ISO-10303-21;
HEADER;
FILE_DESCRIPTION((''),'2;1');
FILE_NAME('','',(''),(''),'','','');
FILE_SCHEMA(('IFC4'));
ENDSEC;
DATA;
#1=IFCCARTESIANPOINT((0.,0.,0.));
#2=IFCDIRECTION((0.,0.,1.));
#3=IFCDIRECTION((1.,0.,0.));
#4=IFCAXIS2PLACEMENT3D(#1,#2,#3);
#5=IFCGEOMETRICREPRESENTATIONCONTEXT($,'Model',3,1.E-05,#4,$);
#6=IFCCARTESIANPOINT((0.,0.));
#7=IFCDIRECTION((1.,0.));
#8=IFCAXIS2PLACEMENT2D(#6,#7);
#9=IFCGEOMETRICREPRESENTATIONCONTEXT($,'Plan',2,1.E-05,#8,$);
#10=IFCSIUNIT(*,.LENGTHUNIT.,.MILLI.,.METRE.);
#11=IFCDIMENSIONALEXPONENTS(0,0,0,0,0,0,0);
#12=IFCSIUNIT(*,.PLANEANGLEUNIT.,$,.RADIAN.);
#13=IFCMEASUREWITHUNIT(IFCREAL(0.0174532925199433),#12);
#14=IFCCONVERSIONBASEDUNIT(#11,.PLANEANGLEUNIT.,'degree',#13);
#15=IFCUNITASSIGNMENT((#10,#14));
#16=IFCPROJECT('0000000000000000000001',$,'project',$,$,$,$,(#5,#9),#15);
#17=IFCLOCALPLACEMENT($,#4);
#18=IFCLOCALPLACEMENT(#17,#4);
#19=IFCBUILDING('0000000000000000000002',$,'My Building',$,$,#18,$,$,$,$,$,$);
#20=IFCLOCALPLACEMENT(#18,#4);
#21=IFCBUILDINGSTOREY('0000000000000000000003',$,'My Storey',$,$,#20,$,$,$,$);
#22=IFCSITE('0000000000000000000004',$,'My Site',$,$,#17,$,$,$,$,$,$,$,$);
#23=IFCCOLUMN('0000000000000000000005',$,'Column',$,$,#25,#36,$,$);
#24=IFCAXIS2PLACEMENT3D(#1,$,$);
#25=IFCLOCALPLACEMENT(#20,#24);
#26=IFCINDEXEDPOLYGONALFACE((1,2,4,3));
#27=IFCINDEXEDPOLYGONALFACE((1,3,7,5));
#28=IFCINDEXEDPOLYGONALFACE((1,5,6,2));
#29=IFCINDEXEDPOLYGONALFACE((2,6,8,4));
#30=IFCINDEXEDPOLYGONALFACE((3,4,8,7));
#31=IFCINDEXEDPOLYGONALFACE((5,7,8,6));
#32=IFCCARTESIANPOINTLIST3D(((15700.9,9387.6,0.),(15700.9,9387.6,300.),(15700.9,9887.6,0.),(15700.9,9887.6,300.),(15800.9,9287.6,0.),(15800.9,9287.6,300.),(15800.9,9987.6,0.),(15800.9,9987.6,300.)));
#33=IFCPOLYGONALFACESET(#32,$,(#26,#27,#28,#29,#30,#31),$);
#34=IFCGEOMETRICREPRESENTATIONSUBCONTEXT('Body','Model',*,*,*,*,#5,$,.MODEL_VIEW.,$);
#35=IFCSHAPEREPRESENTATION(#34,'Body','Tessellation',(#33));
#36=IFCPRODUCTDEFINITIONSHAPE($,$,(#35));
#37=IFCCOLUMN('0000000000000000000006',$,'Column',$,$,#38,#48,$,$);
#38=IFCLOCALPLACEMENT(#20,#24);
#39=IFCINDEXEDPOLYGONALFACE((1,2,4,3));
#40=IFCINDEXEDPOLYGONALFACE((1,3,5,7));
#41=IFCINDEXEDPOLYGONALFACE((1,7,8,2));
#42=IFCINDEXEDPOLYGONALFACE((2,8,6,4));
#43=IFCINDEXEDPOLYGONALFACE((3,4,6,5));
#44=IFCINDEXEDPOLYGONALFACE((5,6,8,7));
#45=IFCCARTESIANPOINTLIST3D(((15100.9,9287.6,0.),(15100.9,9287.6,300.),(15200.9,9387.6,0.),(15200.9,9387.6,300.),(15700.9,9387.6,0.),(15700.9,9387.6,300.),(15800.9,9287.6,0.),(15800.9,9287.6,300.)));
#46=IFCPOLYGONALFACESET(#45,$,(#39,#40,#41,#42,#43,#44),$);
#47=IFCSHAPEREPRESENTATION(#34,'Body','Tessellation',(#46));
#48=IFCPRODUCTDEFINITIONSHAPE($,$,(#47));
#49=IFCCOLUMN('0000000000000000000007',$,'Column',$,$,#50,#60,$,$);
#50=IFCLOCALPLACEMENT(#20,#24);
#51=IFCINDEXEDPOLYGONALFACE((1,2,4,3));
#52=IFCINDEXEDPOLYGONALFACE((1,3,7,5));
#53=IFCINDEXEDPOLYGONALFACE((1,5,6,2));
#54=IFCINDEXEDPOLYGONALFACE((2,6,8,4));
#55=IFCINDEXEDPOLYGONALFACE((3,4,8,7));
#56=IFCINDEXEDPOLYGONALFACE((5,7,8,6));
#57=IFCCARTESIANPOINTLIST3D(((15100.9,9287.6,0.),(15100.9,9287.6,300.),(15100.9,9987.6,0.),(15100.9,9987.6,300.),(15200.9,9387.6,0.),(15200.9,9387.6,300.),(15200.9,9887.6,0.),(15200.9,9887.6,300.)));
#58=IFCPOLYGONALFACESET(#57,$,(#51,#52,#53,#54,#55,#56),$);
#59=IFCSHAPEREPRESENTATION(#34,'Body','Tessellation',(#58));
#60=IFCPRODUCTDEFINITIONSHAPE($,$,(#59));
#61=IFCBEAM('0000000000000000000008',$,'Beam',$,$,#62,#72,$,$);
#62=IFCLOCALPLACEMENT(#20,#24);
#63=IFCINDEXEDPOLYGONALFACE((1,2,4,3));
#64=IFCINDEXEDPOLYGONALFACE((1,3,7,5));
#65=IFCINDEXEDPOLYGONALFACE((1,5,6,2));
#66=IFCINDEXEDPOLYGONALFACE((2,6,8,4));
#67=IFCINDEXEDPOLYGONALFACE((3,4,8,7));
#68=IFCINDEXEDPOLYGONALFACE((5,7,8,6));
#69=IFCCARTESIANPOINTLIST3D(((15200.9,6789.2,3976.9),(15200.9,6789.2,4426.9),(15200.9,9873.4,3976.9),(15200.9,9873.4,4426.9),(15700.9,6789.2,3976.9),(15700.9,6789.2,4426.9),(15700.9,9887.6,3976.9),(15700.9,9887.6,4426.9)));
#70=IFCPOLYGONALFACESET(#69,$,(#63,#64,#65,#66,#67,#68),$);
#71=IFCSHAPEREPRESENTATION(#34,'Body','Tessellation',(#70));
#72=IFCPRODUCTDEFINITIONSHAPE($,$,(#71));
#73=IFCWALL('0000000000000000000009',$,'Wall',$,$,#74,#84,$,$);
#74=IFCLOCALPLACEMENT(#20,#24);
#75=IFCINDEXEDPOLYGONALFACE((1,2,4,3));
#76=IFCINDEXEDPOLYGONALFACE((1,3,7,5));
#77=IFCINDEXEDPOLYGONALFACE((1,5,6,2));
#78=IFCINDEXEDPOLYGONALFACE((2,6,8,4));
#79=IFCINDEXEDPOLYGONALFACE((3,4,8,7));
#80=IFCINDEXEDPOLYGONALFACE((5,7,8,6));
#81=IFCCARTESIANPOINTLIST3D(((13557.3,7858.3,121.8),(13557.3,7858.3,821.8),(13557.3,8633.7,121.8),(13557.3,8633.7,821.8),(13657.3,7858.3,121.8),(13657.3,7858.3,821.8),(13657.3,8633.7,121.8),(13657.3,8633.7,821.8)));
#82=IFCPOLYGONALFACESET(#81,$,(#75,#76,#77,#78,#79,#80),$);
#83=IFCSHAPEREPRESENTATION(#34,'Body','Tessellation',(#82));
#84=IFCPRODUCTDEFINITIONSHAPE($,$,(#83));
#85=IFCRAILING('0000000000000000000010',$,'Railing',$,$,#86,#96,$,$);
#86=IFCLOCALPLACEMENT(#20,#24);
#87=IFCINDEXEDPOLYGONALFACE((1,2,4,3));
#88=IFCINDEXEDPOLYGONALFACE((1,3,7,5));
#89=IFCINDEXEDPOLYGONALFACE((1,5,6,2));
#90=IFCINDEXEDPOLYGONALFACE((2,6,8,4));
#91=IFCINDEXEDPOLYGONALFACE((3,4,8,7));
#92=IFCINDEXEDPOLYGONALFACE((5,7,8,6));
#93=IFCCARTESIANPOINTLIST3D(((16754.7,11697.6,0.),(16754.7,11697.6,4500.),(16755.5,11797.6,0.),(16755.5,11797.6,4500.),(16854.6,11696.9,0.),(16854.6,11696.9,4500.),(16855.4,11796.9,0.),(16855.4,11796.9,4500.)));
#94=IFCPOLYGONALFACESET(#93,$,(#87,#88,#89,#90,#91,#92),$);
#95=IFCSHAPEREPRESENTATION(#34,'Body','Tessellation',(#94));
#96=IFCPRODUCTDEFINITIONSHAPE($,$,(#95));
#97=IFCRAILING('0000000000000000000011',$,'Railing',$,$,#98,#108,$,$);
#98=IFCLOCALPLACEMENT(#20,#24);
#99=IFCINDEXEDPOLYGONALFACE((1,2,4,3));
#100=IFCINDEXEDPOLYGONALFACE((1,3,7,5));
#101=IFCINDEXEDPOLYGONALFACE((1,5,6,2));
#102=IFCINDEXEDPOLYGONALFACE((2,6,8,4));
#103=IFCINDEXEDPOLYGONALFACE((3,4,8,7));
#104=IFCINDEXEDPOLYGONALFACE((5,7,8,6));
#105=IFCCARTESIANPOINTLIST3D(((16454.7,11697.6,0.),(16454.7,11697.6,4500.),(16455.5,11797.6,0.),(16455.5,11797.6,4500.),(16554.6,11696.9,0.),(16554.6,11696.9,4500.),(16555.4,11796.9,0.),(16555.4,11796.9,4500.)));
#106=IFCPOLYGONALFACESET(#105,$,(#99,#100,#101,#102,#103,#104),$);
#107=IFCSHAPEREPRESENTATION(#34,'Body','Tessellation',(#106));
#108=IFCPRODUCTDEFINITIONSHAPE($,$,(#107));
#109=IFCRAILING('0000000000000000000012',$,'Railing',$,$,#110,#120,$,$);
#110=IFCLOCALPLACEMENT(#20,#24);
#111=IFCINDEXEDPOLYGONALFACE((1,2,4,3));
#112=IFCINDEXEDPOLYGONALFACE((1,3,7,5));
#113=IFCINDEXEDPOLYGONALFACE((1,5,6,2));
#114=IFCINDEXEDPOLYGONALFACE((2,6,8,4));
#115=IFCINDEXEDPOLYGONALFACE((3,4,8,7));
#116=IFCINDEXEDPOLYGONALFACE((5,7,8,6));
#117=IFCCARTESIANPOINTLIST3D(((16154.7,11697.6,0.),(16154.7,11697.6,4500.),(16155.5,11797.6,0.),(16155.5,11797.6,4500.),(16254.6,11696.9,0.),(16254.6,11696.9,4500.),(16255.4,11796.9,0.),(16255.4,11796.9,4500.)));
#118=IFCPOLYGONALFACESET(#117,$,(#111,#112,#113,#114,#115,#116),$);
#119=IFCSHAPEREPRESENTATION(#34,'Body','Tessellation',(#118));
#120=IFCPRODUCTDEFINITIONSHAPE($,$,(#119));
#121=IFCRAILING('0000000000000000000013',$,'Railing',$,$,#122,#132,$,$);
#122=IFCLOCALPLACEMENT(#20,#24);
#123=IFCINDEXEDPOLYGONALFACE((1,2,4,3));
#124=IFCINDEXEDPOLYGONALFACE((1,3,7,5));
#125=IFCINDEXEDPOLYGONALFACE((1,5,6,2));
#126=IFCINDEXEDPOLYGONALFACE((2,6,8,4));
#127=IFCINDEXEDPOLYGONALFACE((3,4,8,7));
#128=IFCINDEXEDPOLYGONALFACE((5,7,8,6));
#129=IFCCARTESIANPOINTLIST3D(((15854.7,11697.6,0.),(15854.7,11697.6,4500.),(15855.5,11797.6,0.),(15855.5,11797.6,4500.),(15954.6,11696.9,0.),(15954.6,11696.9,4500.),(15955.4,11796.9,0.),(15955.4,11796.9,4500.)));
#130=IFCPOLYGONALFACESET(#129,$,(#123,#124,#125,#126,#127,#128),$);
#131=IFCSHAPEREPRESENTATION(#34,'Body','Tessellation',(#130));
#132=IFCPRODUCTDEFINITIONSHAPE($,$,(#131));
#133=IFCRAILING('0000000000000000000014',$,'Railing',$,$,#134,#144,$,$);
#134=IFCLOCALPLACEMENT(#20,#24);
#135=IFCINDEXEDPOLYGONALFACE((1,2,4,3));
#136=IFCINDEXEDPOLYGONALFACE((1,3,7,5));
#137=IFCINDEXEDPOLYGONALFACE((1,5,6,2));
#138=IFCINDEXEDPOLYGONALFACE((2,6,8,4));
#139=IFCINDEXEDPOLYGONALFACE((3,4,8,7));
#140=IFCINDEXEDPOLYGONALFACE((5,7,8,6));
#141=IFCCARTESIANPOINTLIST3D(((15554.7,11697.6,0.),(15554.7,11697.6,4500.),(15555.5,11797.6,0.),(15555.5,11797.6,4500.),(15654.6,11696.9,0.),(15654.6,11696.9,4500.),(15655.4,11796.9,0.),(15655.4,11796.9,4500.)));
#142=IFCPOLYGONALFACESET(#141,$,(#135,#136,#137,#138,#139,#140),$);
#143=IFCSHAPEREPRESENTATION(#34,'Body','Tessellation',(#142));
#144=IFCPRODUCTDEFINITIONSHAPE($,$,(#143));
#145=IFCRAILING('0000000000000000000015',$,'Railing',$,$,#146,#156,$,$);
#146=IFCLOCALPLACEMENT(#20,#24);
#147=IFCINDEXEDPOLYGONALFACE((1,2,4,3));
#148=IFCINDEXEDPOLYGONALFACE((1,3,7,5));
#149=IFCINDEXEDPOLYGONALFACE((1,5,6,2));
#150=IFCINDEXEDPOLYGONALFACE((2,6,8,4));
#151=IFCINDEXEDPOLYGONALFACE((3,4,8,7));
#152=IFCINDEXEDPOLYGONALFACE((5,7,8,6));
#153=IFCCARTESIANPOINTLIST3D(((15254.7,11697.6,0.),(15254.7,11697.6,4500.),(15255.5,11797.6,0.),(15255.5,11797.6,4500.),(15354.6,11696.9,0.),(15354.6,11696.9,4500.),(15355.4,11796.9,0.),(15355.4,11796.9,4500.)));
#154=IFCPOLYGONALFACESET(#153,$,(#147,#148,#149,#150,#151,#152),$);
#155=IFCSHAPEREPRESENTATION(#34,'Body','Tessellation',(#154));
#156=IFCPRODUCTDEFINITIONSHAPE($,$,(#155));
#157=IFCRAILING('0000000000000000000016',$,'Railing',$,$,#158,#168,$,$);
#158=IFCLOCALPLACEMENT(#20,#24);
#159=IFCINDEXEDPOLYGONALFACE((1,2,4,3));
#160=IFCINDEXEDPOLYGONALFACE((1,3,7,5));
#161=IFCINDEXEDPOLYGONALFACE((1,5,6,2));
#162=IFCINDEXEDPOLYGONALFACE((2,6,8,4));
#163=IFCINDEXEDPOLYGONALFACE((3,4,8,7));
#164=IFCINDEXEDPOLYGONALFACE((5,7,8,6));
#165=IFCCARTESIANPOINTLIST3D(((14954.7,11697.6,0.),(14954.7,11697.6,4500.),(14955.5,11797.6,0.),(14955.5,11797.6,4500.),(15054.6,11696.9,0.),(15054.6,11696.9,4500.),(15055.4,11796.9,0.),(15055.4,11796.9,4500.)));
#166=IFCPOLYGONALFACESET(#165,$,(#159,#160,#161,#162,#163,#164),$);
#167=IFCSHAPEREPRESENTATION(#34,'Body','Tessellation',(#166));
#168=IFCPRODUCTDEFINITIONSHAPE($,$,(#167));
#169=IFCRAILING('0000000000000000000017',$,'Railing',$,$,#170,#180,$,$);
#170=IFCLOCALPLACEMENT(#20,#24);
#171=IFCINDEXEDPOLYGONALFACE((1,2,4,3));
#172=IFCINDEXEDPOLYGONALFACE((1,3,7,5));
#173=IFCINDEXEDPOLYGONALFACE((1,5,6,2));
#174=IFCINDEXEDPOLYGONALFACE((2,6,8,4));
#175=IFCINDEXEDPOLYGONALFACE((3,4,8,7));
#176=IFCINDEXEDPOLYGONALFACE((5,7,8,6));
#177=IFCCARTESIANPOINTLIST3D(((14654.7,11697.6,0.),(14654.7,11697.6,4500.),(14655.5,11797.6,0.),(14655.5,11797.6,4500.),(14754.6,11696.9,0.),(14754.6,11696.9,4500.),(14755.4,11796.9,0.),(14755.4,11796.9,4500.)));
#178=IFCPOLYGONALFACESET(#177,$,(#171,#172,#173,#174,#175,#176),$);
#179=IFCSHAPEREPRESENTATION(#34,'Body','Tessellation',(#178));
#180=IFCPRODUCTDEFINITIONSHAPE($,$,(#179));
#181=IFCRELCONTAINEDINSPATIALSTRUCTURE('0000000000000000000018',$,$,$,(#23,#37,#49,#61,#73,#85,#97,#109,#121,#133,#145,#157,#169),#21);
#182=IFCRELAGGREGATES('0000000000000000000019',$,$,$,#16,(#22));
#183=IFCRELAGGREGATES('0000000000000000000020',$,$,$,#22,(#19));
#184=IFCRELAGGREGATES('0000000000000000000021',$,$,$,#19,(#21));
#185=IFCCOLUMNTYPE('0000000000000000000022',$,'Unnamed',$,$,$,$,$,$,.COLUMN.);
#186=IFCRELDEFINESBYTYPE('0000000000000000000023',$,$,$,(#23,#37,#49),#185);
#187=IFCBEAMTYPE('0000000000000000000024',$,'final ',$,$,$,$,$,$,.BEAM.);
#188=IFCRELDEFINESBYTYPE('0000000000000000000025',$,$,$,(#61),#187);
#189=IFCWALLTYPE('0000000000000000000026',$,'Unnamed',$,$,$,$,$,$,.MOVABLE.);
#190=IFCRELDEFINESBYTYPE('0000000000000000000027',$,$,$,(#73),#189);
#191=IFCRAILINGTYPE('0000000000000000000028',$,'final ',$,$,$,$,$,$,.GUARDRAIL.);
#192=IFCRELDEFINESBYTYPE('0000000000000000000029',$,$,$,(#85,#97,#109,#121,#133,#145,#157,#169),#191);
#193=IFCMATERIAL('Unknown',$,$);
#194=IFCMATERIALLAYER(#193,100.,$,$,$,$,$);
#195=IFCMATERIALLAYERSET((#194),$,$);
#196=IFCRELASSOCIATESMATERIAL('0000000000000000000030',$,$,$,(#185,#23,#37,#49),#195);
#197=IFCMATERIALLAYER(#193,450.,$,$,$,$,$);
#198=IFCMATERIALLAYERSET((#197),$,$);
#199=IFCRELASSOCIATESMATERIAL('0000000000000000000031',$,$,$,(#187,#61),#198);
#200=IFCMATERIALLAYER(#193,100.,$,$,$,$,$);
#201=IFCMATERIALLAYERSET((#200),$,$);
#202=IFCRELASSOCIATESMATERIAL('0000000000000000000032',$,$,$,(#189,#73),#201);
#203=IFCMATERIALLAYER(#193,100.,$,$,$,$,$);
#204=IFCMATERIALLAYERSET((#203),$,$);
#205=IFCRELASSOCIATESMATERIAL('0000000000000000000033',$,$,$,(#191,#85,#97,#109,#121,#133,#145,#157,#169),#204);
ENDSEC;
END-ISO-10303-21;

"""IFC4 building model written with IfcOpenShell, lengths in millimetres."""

from ifc_helpers import new_model, entity, si_unit, converted_unit, frame, origin_with_axes, origin_2d_with_axis, place, context, subcontext, project, spatial, line, indexed_curve, outline, extrude, material, layer, layer_set, layer_usage, type_object, element, save


model = new_model("IFC4")

# Units and contexts
model_context = context("Model", 3, precision=1e-05, world=origin_with_axes())
plan_context = context("Plan", 2, precision=1e-05, world=origin_2d_with_axis())
body_context = subcontext(model_context, "Body", "Model", "MODEL_VIEW")
ifc_project = project(units=[si_unit("LENGTHUNIT", "METRE", prefix="MILLI"), converted_unit("PLANEANGLEUNIT", "degree", entity("IfcReal", 0.0174532925199433), si_unit("PLANEANGLEUNIT", "RADIAN"), dimensions=[0, 0, 0, 0, 0, 0, 0])], contexts=[model_context, plan_context])

# Site, building, storey
site_placement = place(None, origin_with_axes())
site = spatial("IfcSite", under=ifc_project, at=site_placement, Name="My Site")
building_placement = place(site_placement, origin_with_axes())
building = spatial("IfcBuilding", under=site, at=building_placement, Name="My Building")
storey_placement = place(building_placement, origin_with_axes())
storey = spatial("IfcBuildingStorey", under=building, at=storey_placement, Name="My Storey")

# Columns
ifc_material = material(Name="Unknown")
ifc_layer_1 = layer(ifc_material, 100.0)
ifc_layer_set_1 = layer_set([ifc_layer_1])
column_type = type_object("IfcColumnType", Name="Unnamed", PredefinedType="COLUMN", material=ifc_layer_set_1)
ifc_layer_usage_1 = layer_usage(ifc_layer_set_1, "AXIS2", "POSITIVE", 0.0)
column_1_placement = place(storey_placement, frame((15700.9, 9887.6, 0.0), z_axis=(0.0, 0.0, 1.0), x_axis=(0.0, -1.0, 0.0)))
element("IfcColumn", 1, at=column_1_placement, inside=storey, type_object=column_type, material=ifc_layer_usage_1, Name="Column", context=body_context, shape_type="SweptSolid", body=[
    extrude(outline(indexed_curve([(0.0, 0.0), (-100.0, 100.0), (600.0, 100.0), (500.0, 0.0)], segments=[line(1, 2, 3, 4, 1)])), origin_with_axes(), (0.0, 0.0, 1.0), 300.0),
])
ifc_layer_usage_2 = layer_usage(ifc_layer_set_1, "AXIS2", "POSITIVE", 0.0)
column_2_placement = place(storey_placement, frame((15700.9, 9387.6, 0.0), z_axis=(0.0, 0.0, 1.0), x_axis=(-1.0, 0.0, 0.0)))
element("IfcColumn", 2, at=column_2_placement, inside=storey, type_object=column_type, material=ifc_layer_usage_2, Name="Column", context=body_context, shape_type="SweptSolid", body=[
    extrude(outline(indexed_curve([(0.0, 0.0), (-100.0, 100.0), (600.0, 100.0), (500.0, 0.0)], segments=[line(1, 2, 3, 4, 1)])), origin_with_axes(), (0.0, 0.0, 1.0), 300.0),
])
ifc_layer_usage_3 = layer_usage(ifc_layer_set_1, "AXIS2", "POSITIVE", 0.0)
column_3_placement = place(storey_placement, frame((15200.9, 9387.6, 0.0), z_axis=(0.0, 0.0, 1.0), x_axis=(0.0, 1.0, 0.0)))
element("IfcColumn", 3, at=column_3_placement, inside=storey, type_object=column_type, material=ifc_layer_usage_3, Name="Column", context=body_context, shape_type="SweptSolid", body=[
    extrude(outline(indexed_curve([(0.0, 0.0), (-100.0, 100.0), (600.0, 100.0), (500.0, 0.0)], segments=[line(1, 2, 3, 4, 1)])), origin_with_axes(), (0.0, 0.0, 1.0), 300.0),
])

# Beam
ifc_layer_2 = layer(ifc_material, 450.0)
ifc_layer_set_2 = layer_set([ifc_layer_2])
beam_type = type_object("IfcBeamType", Name="final ", PredefinedType="BEAM", material=ifc_layer_set_2)
ifc_layer_usage_4 = layer_usage(ifc_layer_set_2, "AXIS3", "POSITIVE", -450.0)
beam_1_placement = place(storey_placement, frame((15700.9, 9887.6, 4426.9), z_axis=(0.0, 0.0, 1.0), x_axis=(1.0, 0.0, 0.0)))
element("IfcBeam", 4, at=beam_1_placement, inside=storey, type_object=beam_type, material=ifc_layer_usage_4, Name="Beam", context=body_context, shape_type="SweptSolid", body=[
    extrude(outline(indexed_curve([(0.0, 0.0), (0.0, -3098.3), (-500.0, -3098.3), (-500.0, -14.2), (0.0, 0.0)])), frame((0.0, 0.0, -450.0), z_axis=(0.0, 0.0, 1.0), x_axis=(1.0, 0.0, 0.0)), (0.0, 0.0, 1.0), 450.0),
])

# Wall
ifc_layer_3 = layer(ifc_material, 100.0)
ifc_layer_set_3 = layer_set([ifc_layer_3])
ifc_layer_usage_5 = layer_usage(ifc_layer_set_3, "AXIS2", "POSITIVE", 0.0)
wall_type = type_object("IfcWallType", Name="Unnamed", PredefinedType="MOVABLE", material=ifc_layer_set_3)
wall_placement = place(storey_placement, frame((13557.3, 8633.7, 121.8), z_axis=(0.0, 0.0, 1.0), x_axis=(0.0, -1.0, 0.0)))
element("IfcWall", 5, at=wall_placement, inside=storey, type_object=wall_type, material=ifc_layer_usage_5, Name="Wall", context=body_context, shape_type="SweptSolid", body=[
    extrude(outline(indexed_curve([(0.0, 0.0), (0.0, 100.0), (775.4, 100.0), (775.4, 0.0)], segments=[line(1, 2, 3, 4, 1)])), origin_with_axes(), (0.0, 0.0, 1.0), 700.0),
])

# Railings
ifc_layer_4 = layer(ifc_material, 100.0)
ifc_layer_set_4 = layer_set([ifc_layer_4])
ifc_layer_usage_6 = layer_usage(ifc_layer_set_4, "AXIS2", "POSITIVE", 0.0)
railing_type = type_object("IfcRailingType", Name="final ", PredefinedType="GUARDRAIL", material=ifc_layer_set_4)
railing_1_placement = place(storey_placement, frame((16855.4, 11796.9, 0.0), z_axis=(0.0, 0.0, 1.0), x_axis=(-0.99997, 0.007689, 0.0)))
element("IfcRailing", 6, at=railing_1_placement, inside=storey, type_object=railing_type, material=ifc_layer_usage_6, Name="Railing", context=body_context, shape_type="SweptSolid", body=[
    extrude(outline(indexed_curve([(0.0, 0.0), (0.0, 100.0), (99.8, 100.0), (99.8, 0.0)], segments=[line(1, 2, 3, 4, 1)])), origin_with_axes(), (0.0, 0.0, 1.0), 4500.0),
])
ifc_layer_usage_7 = layer_usage(ifc_layer_set_4, "AXIS2", "POSITIVE", 0.0)
railing_2_placement = place(storey_placement, frame((16555.4, 11796.9, 0.0), z_axis=(0.0, 0.0, 1.0), x_axis=(-0.99997, 0.007689, 0.0)))
element("IfcRailing", 7, at=railing_2_placement, inside=storey, type_object=railing_type, material=ifc_layer_usage_7, Name="Railing", context=body_context, shape_type="SweptSolid", body=[
    extrude(outline(indexed_curve([(0.0, 0.0), (0.0, 100.0), (99.8, 100.0), (99.8, 0.0)], segments=[line(1, 2, 3, 4, 1)])), origin_with_axes(), (0.0, 0.0, 1.0), 4500.0),
])
ifc_layer_usage_8 = layer_usage(ifc_layer_set_4, "AXIS2", "POSITIVE", 0.0)
railing_3_placement = place(storey_placement, frame((16255.4, 11796.9, 0.0), z_axis=(0.0, 0.0, 1.0), x_axis=(-0.99997, 0.007689, 0.0)))
element("IfcRailing", 8, at=railing_3_placement, inside=storey, type_object=railing_type, material=ifc_layer_usage_8, Name="Railing", context=body_context, shape_type="SweptSolid", body=[
    extrude(outline(indexed_curve([(0.0, 0.0), (0.0, 100.0), (99.8, 100.0), (99.8, 0.0)], segments=[line(1, 2, 3, 4, 1)])), origin_with_axes(), (0.0, 0.0, 1.0), 4500.0),
])
ifc_layer_usage_9 = layer_usage(ifc_layer_set_4, "AXIS2", "POSITIVE", 0.0)
railing_4_placement = place(storey_placement, frame((15955.4, 11796.9, 0.0), z_axis=(0.0, 0.0, 1.0), x_axis=(-0.99997, 0.007689, 0.0)))
element("IfcRailing", 9, at=railing_4_placement, inside=storey, type_object=railing_type, material=ifc_layer_usage_9, Name="Railing", context=body_context, shape_type="SweptSolid", body=[
    extrude(outline(indexed_curve([(0.0, 0.0), (0.0, 100.0), (99.8, 100.0), (99.8, 0.0)], segments=[line(1, 2, 3, 4, 1)])), origin_with_axes(), (0.0, 0.0, 1.0), 4500.0),
])
ifc_layer_usage_10 = layer_usage(ifc_layer_set_4, "AXIS2", "POSITIVE", 0.0)
railing_5_placement = place(storey_placement, frame((15655.4, 11796.9, 0.0), z_axis=(0.0, 0.0, 1.0), x_axis=(-0.99997, 0.007689, 0.0)))
element("IfcRailing", 10, at=railing_5_placement, inside=storey, type_object=railing_type, material=ifc_layer_usage_10, Name="Railing", context=body_context, shape_type="SweptSolid", body=[
    extrude(outline(indexed_curve([(0.0, 0.0), (0.0, 100.0), (99.8, 100.0), (99.8, 0.0)], segments=[line(1, 2, 3, 4, 1)])), origin_with_axes(), (0.0, 0.0, 1.0), 4500.0),
])
ifc_layer_usage_11 = layer_usage(ifc_layer_set_4, "AXIS2", "POSITIVE", 0.0)
railing_6_placement = place(storey_placement, frame((15355.4, 11796.9, 0.0), z_axis=(0.0, 0.0, 1.0), x_axis=(-0.99997, 0.007689, 0.0)))
element("IfcRailing", 11, at=railing_6_placement, inside=storey, type_object=railing_type, material=ifc_layer_usage_11, Name="Railing", context=body_context, shape_type="SweptSolid", body=[
    extrude(outline(indexed_curve([(0.0, 0.0), (0.0, 100.0), (99.8, 100.0), (99.8, 0.0)], segments=[line(1, 2, 3, 4, 1)])), origin_with_axes(), (0.0, 0.0, 1.0), 4500.0),
])
ifc_layer_usage_12 = layer_usage(ifc_layer_set_4, "AXIS2", "POSITIVE", 0.0)
railing_7_placement = place(storey_placement, frame((15055.4, 11796.9, 0.0), z_axis=(0.0, 0.0, 1.0), x_axis=(-0.99997, 0.007689, 0.0)))
element("IfcRailing", 12, at=railing_7_placement, inside=storey, type_object=railing_type, material=ifc_layer_usage_12, Name="Railing", context=body_context, shape_type="SweptSolid", body=[
    extrude(outline(indexed_curve([(0.0, 0.0), (0.0, 100.0), (99.8, 100.0), (99.8, 0.0)], segments=[line(1, 2, 3, 4, 1)])), origin_with_axes(), (0.0, 0.0, 1.0), 4500.0),
])
ifc_layer_usage_13 = layer_usage(ifc_layer_set_4, "AXIS2", "POSITIVE", 0.0)
railing_8_placement = place(storey_placement, frame((14755.4, 11796.9, 0.0), z_axis=(0.0, 0.0, 1.0), x_axis=(-0.99997, 0.007689, 0.0)))
element("IfcRailing", 13, at=railing_8_placement, inside=storey, type_object=railing_type, material=ifc_layer_usage_13, Name="Railing", context=body_context, shape_type="SweptSolid", body=[
    extrude(outline(indexed_curve([(0.0, 0.0), (0.0, 100.0), (99.8, 100.0), (99.8, 0.0)], segments=[line(1, 2, 3, 4, 1)])), origin_with_axes(), (0.0, 0.0, 1.0), 4500.0),
])

save(model, "model.ifc")
